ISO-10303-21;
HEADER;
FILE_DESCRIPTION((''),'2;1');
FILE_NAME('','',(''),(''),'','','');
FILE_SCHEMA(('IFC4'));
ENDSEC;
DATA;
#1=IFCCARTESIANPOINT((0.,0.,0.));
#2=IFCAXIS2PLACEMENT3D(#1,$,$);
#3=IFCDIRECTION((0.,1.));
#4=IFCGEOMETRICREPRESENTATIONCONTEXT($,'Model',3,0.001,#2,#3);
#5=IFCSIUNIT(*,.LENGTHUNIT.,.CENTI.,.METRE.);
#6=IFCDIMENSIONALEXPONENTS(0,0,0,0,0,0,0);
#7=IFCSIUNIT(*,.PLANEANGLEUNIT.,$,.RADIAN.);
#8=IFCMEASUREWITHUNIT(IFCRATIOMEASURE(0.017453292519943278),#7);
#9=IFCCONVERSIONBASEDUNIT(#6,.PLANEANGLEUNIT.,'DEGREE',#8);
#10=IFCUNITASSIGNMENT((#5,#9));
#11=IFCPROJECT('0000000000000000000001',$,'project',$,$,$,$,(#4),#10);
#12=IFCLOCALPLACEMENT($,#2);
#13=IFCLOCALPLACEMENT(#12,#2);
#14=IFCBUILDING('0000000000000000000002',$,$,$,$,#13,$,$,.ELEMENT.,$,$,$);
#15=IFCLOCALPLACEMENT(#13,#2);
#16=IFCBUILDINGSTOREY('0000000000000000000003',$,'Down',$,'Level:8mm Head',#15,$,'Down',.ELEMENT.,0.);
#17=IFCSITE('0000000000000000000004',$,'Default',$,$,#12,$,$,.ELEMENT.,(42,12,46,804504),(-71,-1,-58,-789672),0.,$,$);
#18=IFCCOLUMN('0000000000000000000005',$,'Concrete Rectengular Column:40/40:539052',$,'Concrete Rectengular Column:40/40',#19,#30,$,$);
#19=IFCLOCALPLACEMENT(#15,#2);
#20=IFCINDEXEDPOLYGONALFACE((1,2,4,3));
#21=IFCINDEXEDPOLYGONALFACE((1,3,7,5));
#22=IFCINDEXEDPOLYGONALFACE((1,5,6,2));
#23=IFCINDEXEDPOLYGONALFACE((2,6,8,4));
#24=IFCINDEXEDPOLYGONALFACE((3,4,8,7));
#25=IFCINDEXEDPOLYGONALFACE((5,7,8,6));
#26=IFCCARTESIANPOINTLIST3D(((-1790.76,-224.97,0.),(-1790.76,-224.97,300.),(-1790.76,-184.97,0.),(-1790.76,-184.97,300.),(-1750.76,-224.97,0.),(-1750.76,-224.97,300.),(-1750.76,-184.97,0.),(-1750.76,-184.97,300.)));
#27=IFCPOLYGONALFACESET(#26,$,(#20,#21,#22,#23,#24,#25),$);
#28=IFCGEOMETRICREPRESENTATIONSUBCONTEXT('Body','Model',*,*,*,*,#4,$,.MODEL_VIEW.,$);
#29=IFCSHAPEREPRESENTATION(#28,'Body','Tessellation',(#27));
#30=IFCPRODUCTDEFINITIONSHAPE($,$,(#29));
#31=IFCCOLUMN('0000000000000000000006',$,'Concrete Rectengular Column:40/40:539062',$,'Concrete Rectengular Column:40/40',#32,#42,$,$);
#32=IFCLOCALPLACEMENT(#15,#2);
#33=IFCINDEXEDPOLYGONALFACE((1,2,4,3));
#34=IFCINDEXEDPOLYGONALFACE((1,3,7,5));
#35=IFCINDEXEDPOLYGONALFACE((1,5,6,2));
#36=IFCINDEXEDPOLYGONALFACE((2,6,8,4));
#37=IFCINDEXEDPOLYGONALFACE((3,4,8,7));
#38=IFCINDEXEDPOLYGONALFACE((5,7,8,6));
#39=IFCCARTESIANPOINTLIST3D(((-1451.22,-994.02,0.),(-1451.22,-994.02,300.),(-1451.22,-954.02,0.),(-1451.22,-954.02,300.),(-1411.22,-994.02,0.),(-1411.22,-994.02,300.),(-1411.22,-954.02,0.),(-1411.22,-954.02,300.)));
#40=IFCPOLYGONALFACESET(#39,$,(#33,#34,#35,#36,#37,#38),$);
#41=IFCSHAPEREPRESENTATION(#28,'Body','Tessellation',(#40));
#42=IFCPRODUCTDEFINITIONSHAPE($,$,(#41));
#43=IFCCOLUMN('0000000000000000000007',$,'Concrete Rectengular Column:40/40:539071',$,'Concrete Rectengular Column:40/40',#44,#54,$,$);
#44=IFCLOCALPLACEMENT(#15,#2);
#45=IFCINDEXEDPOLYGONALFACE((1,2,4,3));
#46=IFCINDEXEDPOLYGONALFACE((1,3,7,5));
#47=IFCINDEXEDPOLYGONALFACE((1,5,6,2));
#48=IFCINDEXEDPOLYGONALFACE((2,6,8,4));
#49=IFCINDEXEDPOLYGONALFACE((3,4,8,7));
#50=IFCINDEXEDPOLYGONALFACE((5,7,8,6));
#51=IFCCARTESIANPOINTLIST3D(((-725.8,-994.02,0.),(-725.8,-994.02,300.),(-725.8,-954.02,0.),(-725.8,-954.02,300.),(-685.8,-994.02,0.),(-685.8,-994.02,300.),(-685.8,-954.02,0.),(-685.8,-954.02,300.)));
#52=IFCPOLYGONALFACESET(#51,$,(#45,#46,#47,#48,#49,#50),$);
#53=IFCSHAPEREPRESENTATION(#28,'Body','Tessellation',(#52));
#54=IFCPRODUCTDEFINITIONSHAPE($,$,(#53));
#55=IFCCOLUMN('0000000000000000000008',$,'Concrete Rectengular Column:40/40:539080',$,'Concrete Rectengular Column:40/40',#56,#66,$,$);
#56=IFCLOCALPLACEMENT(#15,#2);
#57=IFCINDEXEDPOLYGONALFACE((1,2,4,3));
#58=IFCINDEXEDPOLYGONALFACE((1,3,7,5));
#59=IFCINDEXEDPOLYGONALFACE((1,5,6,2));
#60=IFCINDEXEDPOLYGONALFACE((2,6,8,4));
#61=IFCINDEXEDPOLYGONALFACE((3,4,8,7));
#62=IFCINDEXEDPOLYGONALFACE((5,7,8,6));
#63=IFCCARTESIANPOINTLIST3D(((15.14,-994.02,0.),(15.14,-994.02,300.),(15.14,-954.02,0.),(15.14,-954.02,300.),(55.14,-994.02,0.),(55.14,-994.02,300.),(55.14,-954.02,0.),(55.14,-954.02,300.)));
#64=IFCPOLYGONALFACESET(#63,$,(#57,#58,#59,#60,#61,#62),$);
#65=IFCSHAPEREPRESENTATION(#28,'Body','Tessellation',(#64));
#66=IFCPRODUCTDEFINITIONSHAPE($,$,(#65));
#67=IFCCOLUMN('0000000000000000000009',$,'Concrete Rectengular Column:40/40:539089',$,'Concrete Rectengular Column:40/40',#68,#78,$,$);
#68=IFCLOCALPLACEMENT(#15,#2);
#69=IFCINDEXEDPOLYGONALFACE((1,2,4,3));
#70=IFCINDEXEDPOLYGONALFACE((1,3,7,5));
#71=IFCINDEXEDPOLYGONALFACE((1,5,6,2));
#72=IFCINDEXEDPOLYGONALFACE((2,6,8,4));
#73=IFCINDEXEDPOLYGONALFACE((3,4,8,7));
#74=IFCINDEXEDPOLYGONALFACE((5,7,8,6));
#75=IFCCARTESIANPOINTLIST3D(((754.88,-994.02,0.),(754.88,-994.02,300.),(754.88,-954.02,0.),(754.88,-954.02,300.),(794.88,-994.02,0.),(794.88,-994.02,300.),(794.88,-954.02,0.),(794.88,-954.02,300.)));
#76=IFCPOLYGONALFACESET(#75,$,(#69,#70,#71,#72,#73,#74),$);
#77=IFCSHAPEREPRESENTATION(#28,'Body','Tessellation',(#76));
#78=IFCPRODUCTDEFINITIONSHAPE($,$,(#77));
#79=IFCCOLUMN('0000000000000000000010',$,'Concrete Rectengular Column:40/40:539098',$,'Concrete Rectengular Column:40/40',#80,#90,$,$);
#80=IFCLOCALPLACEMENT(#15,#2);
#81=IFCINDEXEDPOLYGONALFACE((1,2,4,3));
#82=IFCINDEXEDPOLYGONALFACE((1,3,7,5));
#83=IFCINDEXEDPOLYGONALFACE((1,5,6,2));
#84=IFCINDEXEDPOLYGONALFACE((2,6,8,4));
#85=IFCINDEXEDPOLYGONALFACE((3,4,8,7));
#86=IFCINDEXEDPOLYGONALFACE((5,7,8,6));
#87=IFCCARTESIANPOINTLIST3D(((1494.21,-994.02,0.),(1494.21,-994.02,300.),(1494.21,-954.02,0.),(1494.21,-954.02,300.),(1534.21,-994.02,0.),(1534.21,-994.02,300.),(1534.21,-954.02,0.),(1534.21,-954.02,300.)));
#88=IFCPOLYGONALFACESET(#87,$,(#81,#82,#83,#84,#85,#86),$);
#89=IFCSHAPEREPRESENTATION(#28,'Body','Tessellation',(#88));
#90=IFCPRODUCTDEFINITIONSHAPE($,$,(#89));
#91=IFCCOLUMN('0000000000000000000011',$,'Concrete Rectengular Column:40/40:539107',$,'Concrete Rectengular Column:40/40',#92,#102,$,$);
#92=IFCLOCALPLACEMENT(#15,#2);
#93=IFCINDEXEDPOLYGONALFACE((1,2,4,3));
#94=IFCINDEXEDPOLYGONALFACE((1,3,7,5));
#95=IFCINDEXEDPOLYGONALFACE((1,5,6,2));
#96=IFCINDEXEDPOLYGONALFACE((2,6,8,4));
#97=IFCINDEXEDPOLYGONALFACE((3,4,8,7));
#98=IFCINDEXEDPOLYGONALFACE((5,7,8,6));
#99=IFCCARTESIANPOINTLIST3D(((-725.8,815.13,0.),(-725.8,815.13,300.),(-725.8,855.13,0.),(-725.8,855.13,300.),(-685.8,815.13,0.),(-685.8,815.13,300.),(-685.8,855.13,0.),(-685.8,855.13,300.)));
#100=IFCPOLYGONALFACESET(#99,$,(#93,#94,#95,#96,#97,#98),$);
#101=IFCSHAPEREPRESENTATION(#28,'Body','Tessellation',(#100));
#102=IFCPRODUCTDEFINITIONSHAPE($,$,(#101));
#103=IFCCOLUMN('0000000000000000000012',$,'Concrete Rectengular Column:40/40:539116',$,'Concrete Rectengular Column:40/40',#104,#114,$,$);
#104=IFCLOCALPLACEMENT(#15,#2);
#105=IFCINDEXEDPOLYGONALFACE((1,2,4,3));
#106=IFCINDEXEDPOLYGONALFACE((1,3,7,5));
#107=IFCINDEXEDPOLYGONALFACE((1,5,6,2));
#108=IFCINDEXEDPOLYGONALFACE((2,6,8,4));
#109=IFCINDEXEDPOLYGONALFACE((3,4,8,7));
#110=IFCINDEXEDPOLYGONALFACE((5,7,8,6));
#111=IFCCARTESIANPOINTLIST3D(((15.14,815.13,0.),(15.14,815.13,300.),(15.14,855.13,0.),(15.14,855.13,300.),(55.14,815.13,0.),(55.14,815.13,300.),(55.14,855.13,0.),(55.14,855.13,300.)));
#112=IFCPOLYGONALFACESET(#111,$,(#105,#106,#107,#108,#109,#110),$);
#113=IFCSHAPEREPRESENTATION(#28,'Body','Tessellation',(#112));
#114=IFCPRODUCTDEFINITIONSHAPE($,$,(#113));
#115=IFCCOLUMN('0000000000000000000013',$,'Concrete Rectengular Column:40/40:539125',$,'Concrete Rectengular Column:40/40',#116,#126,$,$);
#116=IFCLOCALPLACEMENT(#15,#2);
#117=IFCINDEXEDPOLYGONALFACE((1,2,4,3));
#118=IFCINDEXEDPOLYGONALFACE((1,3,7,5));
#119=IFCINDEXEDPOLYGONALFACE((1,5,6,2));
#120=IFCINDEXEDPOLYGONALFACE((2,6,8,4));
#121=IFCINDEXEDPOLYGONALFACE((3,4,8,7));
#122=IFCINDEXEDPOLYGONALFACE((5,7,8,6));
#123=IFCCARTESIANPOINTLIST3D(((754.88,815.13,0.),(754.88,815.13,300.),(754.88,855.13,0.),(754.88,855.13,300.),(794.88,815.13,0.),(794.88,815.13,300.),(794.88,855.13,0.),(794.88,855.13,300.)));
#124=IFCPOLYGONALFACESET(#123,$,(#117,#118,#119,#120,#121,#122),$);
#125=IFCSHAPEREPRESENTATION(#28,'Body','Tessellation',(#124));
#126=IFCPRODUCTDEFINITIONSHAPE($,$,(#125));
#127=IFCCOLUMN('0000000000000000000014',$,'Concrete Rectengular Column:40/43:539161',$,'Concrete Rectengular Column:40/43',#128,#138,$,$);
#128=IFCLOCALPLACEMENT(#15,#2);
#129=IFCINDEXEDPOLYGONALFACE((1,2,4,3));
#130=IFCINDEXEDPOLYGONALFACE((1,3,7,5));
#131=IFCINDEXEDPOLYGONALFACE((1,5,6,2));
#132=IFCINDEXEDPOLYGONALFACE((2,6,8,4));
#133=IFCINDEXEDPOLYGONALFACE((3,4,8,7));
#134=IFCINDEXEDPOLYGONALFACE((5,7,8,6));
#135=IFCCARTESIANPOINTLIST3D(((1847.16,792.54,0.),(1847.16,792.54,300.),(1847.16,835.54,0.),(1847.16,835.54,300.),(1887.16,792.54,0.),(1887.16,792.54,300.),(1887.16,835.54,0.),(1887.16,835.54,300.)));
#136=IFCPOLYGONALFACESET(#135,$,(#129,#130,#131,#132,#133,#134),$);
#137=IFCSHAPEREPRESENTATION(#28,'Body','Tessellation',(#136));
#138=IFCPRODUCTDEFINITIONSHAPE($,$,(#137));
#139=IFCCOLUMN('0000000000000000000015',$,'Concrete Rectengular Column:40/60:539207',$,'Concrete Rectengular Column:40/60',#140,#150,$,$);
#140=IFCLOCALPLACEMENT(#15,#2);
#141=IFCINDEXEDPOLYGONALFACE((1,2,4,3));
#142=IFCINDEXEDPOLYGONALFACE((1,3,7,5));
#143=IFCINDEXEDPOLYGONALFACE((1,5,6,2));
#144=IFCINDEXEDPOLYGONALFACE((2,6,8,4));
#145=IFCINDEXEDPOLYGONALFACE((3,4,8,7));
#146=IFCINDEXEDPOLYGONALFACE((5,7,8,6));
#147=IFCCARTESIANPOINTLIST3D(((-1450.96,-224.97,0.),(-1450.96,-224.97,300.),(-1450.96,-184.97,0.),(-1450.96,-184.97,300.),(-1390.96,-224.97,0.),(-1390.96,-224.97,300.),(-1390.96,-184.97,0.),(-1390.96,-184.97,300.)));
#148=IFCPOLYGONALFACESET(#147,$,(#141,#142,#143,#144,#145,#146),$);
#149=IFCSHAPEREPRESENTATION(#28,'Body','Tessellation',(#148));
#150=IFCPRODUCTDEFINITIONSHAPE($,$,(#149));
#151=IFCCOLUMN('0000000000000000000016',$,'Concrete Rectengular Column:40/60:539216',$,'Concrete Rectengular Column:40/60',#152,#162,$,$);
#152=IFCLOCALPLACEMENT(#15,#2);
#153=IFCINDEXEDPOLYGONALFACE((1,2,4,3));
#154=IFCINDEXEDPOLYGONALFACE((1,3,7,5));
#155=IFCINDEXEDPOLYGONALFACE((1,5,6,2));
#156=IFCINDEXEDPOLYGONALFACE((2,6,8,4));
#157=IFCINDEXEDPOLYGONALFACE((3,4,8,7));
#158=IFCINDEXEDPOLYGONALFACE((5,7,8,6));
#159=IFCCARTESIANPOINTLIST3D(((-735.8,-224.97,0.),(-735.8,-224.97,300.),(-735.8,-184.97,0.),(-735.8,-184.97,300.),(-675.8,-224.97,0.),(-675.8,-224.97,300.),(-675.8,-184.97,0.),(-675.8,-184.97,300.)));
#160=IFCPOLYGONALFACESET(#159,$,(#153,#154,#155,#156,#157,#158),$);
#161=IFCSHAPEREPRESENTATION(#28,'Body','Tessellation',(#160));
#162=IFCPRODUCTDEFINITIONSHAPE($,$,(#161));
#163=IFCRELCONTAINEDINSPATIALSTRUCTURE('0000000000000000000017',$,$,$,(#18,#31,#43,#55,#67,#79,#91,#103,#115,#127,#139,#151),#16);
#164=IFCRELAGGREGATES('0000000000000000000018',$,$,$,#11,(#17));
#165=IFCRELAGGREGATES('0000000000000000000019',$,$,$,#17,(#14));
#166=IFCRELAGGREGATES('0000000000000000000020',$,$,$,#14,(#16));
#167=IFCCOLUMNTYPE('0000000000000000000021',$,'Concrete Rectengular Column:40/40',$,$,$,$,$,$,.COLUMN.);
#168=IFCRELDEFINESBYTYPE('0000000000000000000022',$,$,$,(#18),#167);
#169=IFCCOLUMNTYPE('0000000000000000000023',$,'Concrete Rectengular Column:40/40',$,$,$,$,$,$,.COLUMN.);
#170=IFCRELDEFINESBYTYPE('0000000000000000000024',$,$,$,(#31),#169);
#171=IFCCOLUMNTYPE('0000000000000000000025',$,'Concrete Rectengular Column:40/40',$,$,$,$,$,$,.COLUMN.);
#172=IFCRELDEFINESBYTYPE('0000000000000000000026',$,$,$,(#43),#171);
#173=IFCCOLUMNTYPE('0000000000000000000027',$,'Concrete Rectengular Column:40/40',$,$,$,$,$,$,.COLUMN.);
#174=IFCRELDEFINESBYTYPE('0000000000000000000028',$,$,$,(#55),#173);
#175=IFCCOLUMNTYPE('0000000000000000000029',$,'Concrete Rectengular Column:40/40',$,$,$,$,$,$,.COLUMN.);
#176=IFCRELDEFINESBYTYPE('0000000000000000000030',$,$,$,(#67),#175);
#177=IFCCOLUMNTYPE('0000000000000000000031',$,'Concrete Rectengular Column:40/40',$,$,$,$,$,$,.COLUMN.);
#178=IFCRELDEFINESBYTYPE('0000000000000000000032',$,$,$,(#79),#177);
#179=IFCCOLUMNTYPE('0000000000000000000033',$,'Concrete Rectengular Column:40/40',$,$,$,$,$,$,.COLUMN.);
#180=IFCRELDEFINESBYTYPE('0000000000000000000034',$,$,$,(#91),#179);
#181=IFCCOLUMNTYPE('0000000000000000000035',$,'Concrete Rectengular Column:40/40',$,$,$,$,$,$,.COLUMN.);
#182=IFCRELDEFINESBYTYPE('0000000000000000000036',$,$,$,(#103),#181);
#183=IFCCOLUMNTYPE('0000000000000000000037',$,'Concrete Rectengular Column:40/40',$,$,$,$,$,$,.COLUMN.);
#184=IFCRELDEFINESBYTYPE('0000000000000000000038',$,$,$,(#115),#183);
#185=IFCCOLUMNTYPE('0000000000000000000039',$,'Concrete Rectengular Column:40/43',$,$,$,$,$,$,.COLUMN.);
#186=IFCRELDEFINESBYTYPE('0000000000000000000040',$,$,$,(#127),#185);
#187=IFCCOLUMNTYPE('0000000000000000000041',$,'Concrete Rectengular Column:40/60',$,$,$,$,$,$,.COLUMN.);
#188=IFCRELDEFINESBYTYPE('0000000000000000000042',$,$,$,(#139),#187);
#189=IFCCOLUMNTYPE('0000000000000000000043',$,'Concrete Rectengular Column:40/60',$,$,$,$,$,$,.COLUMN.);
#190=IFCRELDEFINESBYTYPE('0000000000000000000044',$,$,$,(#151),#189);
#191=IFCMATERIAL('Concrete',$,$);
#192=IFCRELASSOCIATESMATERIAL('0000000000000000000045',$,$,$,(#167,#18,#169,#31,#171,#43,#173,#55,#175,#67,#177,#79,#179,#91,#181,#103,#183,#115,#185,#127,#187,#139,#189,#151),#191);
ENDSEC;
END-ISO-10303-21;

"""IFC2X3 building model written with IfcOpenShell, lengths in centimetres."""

from ifc_helpers import new_model, entity, si_unit, converted_unit, direction, frame, frame_2d, origin, origin_2d_with_axis, place, context, subcontext, project, spatial, rectangle, extrude, source, transform, mapped, material, type_object, type_shapes, element, save


model = new_model("IFC2X3")

# Units and contexts
model_context = context("Model", 3, precision=0.001, world=origin(), true_north=direction((0.0, 1.0)))
body_context = subcontext(model_context, "Body", "Model", "MODEL_VIEW")
ifc_project = project(units=[si_unit("LENGTHUNIT", "METRE", prefix="CENTI"), converted_unit("PLANEANGLEUNIT", "DEGREE", entity("IfcRatioMeasure", 0.017453292519943278), si_unit("PLANEANGLEUNIT", "RADIAN"), dimensions=[0, 0, 0, 0, 0, 0, 0])], contexts=[model_context])

# Site, building, storey
site_placement = place(None, origin())
site = spatial("IfcSite", under=ifc_project, at=site_placement, Name="Default", CompositionType="ELEMENT", RefLatitude=(42, 12, 46, 804504), RefLongitude=(-71, -1, -58, -789672), RefElevation=0.0)
building_placement = place(site_placement, origin())
building = spatial("IfcBuilding", under=site, at=building_placement, CompositionType="ELEMENT")
storey_placement = place(building_placement, origin())
storey = spatial("IfcBuildingStorey", under=building, at=storey_placement, Name="Down", ObjectType="Level:8mm Head", LongName="Down", CompositionType="ELEMENT", Elevation=0.0)

# Columns
ifc_material = material(Name="Concrete")
column_type_1 = type_object("IfcColumnType", Name="Concrete Rectengular Column:40/40", PredefinedType="COLUMN", material=ifc_material)
shared_shape_1 = source(origin(), body_context, "Body", "SweptSolid", [
    extrude(rectangle(XDim=40.0, YDim=40.0, at=origin_2d_with_axis()), frame((-1770.76, -204.97, 0.0), z_axis=(0.0, 0.0, 1.0), x_axis=(0.0, -1.0, 0.0)), (0.0, 0.0, 1.0), 300.0),
])
type_shapes(column_type_1, [shared_shape_1])
column_1_placement = place(storey_placement, origin())
element("IfcColumn", 1, at=column_1_placement, inside=storey, type_object=column_type_1, material=ifc_material, Name="Concrete Rectengular Column:40/40:539052", ObjectType="Concrete Rectengular Column:40/40", context=body_context, shape_type="MappedRepresentation", body=[
    mapped(shared_shape_1, transform((0.0, 0.0, 0.0), scale=1.0)),
])
column_type_2 = type_object("IfcColumnType", Name="Concrete Rectengular Column:40/40", PredefinedType="COLUMN", material=ifc_material)
shared_shape_2 = source(origin(), body_context, "Body", "SweptSolid", [
    extrude(rectangle(XDim=40.0, YDim=40.0, at=frame_2d((0.0, 0.0), x_axis=(1.0, 0.0))), frame((-1431.22, -974.02, 0.0), z_axis=(0.0, 0.0, 1.0), x_axis=(0.0, -1.0, 0.0)), (0.0, 0.0, 1.0), 300.0),
])
type_shapes(column_type_2, [shared_shape_2])
column_2_placement = place(storey_placement, origin())
element("IfcColumn", 2, at=column_2_placement, inside=storey, type_object=column_type_2, material=ifc_material, Name="Concrete Rectengular Column:40/40:539062", ObjectType="Concrete Rectengular Column:40/40", context=body_context, shape_type="MappedRepresentation", body=[
    mapped(shared_shape_2, transform((0.0, 0.0, 0.0), scale=1.0)),
])
column_type_3 = type_object("IfcColumnType", Name="Concrete Rectengular Column:40/40", PredefinedType="COLUMN", material=ifc_material)
shared_shape_3 = source(origin(), body_context, "Body", "SweptSolid", [
    extrude(rectangle(XDim=40.0, YDim=40.0, at=frame_2d((0.0, 0.0), x_axis=(1.0, 0.0))), frame((-705.8, -974.02, 0.0), z_axis=(0.0, 0.0, 1.0), x_axis=(0.0, -1.0, 0.0)), (0.0, 0.0, 1.0), 300.0),
])
type_shapes(column_type_3, [shared_shape_3])
column_3_placement = place(storey_placement, origin())
element("IfcColumn", 3, at=column_3_placement, inside=storey, type_object=column_type_3, material=ifc_material, Name="Concrete Rectengular Column:40/40:539071", ObjectType="Concrete Rectengular Column:40/40", context=body_context, shape_type="MappedRepresentation", body=[
    mapped(shared_shape_3, transform((0.0, 0.0, 0.0), scale=1.0)),
])
column_type_4 = type_object("IfcColumnType", Name="Concrete Rectengular Column:40/40", PredefinedType="COLUMN", material=ifc_material)
shared_shape_4 = source(origin(), body_context, "Body", "SweptSolid", [
    extrude(rectangle(XDim=40.0, YDim=40.0, at=frame_2d((0.0, 0.0), x_axis=(1.0, 0.0))), frame((35.14, -974.02, 0.0), z_axis=(0.0, 0.0, 1.0), x_axis=(0.0, -1.0, 0.0)), (0.0, 0.0, 1.0), 300.0),
])
type_shapes(column_type_4, [shared_shape_4])
column_4_placement = place(storey_placement, origin())
element("IfcColumn", 4, at=column_4_placement, inside=storey, type_object=column_type_4, material=ifc_material, Name="Concrete Rectengular Column:40/40:539080", ObjectType="Concrete Rectengular Column:40/40", context=body_context, shape_type="MappedRepresentation", body=[
    mapped(shared_shape_4, transform((0.0, 0.0, 0.0), scale=1.0)),
])
column_type_5 = type_object("IfcColumnType", Name="Concrete Rectengular Column:40/40", PredefinedType="COLUMN", material=ifc_material)
shared_shape_5 = source(origin(), body_context, "Body", "SweptSolid", [
    extrude(rectangle(XDim=40.0, YDim=40.0, at=frame_2d((0.0, 0.0), x_axis=(1.0, 0.0))), frame((774.88, -974.02, 0.0), z_axis=(0.0, 0.0, 1.0), x_axis=(0.0, -1.0, 0.0)), (0.0, 0.0, 1.0), 300.0),
])
type_shapes(column_type_5, [shared_shape_5])
column_5_placement = place(storey_placement, origin())
element("IfcColumn", 5, at=column_5_placement, inside=storey, type_object=column_type_5, material=ifc_material, Name="Concrete Rectengular Column:40/40:539089", ObjectType="Concrete Rectengular Column:40/40", context=body_context, shape_type="MappedRepresentation", body=[
    mapped(shared_shape_5, transform((0.0, 0.0, 0.0), scale=1.0)),
])
column_type_6 = type_object("IfcColumnType", Name="Concrete Rectengular Column:40/40", PredefinedType="COLUMN", material=ifc_material)
shared_shape_6 = source(origin(), body_context, "Body", "SweptSolid", [
    extrude(rectangle(XDim=40.0, YDim=40.0, at=frame_2d((0.0, 0.0), x_axis=(1.0, 0.0))), frame((1514.21, -974.02, 0.0), z_axis=(0.0, 0.0, 1.0), x_axis=(0.0, -1.0, 0.0)), (0.0, 0.0, 1.0), 300.0),
])
type_shapes(column_type_6, [shared_shape_6])
column_6_placement = place(storey_placement, origin())
element("IfcColumn", 6, at=column_6_placement, inside=storey, type_object=column_type_6, material=ifc_material, Name="Concrete Rectengular Column:40/40:539098", ObjectType="Concrete Rectengular Column:40/40", context=body_context, shape_type="MappedRepresentation", body=[
    mapped(shared_shape_6, transform((0.0, 0.0, 0.0), scale=1.0)),
])
column_type_7 = type_object("IfcColumnType", Name="Concrete Rectengular Column:40/40", PredefinedType="COLUMN", material=ifc_material)
shared_shape_7 = source(origin(), body_context, "Body", "SweptSolid", [
    extrude(rectangle(XDim=40.0, YDim=40.0, at=origin_2d_with_axis()), frame((-705.8, 835.13, 0.0), z_axis=(0.0, 0.0, 1.0), x_axis=(0.0, -1.0, 0.0)), (0.0, 0.0, 1.0), 300.0),
])
type_shapes(column_type_7, [shared_shape_7])
column_7_placement = place(storey_placement, origin())
element("IfcColumn", 7, at=column_7_placement, inside=storey, type_object=column_type_7, material=ifc_material, Name="Concrete Rectengular Column:40/40:539107", ObjectType="Concrete Rectengular Column:40/40", context=body_context, shape_type="MappedRepresentation", body=[
    mapped(shared_shape_7, transform((0.0, 0.0, 0.0), scale=1.0)),
])
column_type_8 = type_object("IfcColumnType", Name="Concrete Rectengular Column:40/40", PredefinedType="COLUMN", material=ifc_material)
shared_shape_8 = source(origin(), body_context, "Body", "SweptSolid", [
    extrude(rectangle(XDim=40.0, YDim=40.0, at=frame_2d((0.0, 0.0), x_axis=(1.0, 0.0))), frame((35.14, 835.13, 0.0), z_axis=(0.0, 0.0, 1.0), x_axis=(0.0, -1.0, 0.0)), (0.0, 0.0, 1.0), 300.0),
])
type_shapes(column_type_8, [shared_shape_8])
column_8_placement = place(storey_placement, origin())
element("IfcColumn", 8, at=column_8_placement, inside=storey, type_object=column_type_8, material=ifc_material, Name="Concrete Rectengular Column:40/40:539116", ObjectType="Concrete Rectengular Column:40/40", context=body_context, shape_type="MappedRepresentation", body=[
    mapped(shared_shape_8, transform((0.0, 0.0, 0.0), scale=1.0)),
])
column_type_9 = type_object("IfcColumnType", Name="Concrete Rectengular Column:40/40", PredefinedType="COLUMN", material=ifc_material)
shared_shape_9 = source(origin(), body_context, "Body", "SweptSolid", [
    extrude(rectangle(XDim=40.0, YDim=40.0, at=origin_2d_with_axis()), frame((774.88, 835.13, 0.0), z_axis=(0.0, 0.0, 1.0), x_axis=(0.0, -1.0, 0.0)), (0.0, 0.0, 1.0), 300.0),
])
type_shapes(column_type_9, [shared_shape_9])
column_9_placement = place(storey_placement, origin())
element("IfcColumn", 9, at=column_9_placement, inside=storey, type_object=column_type_9, material=ifc_material, Name="Concrete Rectengular Column:40/40:539125", ObjectType="Concrete Rectengular Column:40/40", context=body_context, shape_type="MappedRepresentation", body=[
    mapped(shared_shape_9, transform((0.0, 0.0, 0.0), scale=1.0)),
])
column_type_10 = type_object("IfcColumnType", Name="Concrete Rectengular Column:40/43", PredefinedType="COLUMN", material=ifc_material)
shared_shape_10 = source(origin(), body_context, "Body", "SweptSolid", [
    extrude(rectangle(XDim=43.0, YDim=40.0, at=origin_2d_with_axis()), frame((1867.16, 814.04, 0.0), z_axis=(0.0, 0.0, 1.0), x_axis=(0.0, -1.0, 0.0)), (0.0, 0.0, 1.0), 300.0),
])
type_shapes(column_type_10, [shared_shape_10])
column_10_placement = place(storey_placement, origin())
element("IfcColumn", 10, at=column_10_placement, inside=storey, type_object=column_type_10, material=ifc_material, Name="Concrete Rectengular Column:40/43:539161", ObjectType="Concrete Rectengular Column:40/43", context=body_context, shape_type="MappedRepresentation", body=[
    mapped(shared_shape_10, transform((0.0, 0.0, 0.0), scale=1.0)),
])
column_type_11 = type_object("IfcColumnType", Name="Concrete Rectengular Column:40/60", PredefinedType="COLUMN", material=ifc_material)
shared_shape_11 = source(origin(), body_context, "Body", "SweptSolid", [
    extrude(rectangle(XDim=40.0, YDim=60.0, at=frame_2d((0.0, 0.0), x_axis=(1.0, 0.0))), frame((-1420.96, -204.97, 0.0), z_axis=(0.0, 0.0, 1.0), x_axis=(0.0, -1.0, 0.0)), (0.0, 0.0, 1.0), 300.0),
])
type_shapes(column_type_11, [shared_shape_11])
column_11_placement = place(storey_placement, origin())
element("IfcColumn", 11, at=column_11_placement, inside=storey, type_object=column_type_11, material=ifc_material, Name="Concrete Rectengular Column:40/60:539207", ObjectType="Concrete Rectengular Column:40/60", context=body_context, shape_type="MappedRepresentation", body=[
    mapped(shared_shape_11, transform((0.0, 0.0, 0.0), scale=1.0)),
])
column_type_12 = type_object("IfcColumnType", Name="Concrete Rectengular Column:40/60", PredefinedType="COLUMN", material=ifc_material)
shared_shape_12 = source(origin(), body_context, "Body", "SweptSolid", [
    extrude(rectangle(XDim=40.0, YDim=60.0, at=origin_2d_with_axis()), frame((-705.8, -204.97, 0.0), z_axis=(0.0, 0.0, 1.0), x_axis=(0.0, -1.0, 0.0)), (0.0, 0.0, 1.0), 300.0),
])
type_shapes(column_type_12, [shared_shape_12])
column_12_placement = place(storey_placement, origin())
element("IfcColumn", 12, at=column_12_placement, inside=storey, type_object=column_type_12, material=ifc_material, Name="Concrete Rectengular Column:40/60:539216", ObjectType="Concrete Rectengular Column:40/60", context=body_context, shape_type="MappedRepresentation", body=[
    mapped(shared_shape_12, transform((0.0, 0.0, 0.0), scale=1.0)),
])

save(model, "model.ifc")
